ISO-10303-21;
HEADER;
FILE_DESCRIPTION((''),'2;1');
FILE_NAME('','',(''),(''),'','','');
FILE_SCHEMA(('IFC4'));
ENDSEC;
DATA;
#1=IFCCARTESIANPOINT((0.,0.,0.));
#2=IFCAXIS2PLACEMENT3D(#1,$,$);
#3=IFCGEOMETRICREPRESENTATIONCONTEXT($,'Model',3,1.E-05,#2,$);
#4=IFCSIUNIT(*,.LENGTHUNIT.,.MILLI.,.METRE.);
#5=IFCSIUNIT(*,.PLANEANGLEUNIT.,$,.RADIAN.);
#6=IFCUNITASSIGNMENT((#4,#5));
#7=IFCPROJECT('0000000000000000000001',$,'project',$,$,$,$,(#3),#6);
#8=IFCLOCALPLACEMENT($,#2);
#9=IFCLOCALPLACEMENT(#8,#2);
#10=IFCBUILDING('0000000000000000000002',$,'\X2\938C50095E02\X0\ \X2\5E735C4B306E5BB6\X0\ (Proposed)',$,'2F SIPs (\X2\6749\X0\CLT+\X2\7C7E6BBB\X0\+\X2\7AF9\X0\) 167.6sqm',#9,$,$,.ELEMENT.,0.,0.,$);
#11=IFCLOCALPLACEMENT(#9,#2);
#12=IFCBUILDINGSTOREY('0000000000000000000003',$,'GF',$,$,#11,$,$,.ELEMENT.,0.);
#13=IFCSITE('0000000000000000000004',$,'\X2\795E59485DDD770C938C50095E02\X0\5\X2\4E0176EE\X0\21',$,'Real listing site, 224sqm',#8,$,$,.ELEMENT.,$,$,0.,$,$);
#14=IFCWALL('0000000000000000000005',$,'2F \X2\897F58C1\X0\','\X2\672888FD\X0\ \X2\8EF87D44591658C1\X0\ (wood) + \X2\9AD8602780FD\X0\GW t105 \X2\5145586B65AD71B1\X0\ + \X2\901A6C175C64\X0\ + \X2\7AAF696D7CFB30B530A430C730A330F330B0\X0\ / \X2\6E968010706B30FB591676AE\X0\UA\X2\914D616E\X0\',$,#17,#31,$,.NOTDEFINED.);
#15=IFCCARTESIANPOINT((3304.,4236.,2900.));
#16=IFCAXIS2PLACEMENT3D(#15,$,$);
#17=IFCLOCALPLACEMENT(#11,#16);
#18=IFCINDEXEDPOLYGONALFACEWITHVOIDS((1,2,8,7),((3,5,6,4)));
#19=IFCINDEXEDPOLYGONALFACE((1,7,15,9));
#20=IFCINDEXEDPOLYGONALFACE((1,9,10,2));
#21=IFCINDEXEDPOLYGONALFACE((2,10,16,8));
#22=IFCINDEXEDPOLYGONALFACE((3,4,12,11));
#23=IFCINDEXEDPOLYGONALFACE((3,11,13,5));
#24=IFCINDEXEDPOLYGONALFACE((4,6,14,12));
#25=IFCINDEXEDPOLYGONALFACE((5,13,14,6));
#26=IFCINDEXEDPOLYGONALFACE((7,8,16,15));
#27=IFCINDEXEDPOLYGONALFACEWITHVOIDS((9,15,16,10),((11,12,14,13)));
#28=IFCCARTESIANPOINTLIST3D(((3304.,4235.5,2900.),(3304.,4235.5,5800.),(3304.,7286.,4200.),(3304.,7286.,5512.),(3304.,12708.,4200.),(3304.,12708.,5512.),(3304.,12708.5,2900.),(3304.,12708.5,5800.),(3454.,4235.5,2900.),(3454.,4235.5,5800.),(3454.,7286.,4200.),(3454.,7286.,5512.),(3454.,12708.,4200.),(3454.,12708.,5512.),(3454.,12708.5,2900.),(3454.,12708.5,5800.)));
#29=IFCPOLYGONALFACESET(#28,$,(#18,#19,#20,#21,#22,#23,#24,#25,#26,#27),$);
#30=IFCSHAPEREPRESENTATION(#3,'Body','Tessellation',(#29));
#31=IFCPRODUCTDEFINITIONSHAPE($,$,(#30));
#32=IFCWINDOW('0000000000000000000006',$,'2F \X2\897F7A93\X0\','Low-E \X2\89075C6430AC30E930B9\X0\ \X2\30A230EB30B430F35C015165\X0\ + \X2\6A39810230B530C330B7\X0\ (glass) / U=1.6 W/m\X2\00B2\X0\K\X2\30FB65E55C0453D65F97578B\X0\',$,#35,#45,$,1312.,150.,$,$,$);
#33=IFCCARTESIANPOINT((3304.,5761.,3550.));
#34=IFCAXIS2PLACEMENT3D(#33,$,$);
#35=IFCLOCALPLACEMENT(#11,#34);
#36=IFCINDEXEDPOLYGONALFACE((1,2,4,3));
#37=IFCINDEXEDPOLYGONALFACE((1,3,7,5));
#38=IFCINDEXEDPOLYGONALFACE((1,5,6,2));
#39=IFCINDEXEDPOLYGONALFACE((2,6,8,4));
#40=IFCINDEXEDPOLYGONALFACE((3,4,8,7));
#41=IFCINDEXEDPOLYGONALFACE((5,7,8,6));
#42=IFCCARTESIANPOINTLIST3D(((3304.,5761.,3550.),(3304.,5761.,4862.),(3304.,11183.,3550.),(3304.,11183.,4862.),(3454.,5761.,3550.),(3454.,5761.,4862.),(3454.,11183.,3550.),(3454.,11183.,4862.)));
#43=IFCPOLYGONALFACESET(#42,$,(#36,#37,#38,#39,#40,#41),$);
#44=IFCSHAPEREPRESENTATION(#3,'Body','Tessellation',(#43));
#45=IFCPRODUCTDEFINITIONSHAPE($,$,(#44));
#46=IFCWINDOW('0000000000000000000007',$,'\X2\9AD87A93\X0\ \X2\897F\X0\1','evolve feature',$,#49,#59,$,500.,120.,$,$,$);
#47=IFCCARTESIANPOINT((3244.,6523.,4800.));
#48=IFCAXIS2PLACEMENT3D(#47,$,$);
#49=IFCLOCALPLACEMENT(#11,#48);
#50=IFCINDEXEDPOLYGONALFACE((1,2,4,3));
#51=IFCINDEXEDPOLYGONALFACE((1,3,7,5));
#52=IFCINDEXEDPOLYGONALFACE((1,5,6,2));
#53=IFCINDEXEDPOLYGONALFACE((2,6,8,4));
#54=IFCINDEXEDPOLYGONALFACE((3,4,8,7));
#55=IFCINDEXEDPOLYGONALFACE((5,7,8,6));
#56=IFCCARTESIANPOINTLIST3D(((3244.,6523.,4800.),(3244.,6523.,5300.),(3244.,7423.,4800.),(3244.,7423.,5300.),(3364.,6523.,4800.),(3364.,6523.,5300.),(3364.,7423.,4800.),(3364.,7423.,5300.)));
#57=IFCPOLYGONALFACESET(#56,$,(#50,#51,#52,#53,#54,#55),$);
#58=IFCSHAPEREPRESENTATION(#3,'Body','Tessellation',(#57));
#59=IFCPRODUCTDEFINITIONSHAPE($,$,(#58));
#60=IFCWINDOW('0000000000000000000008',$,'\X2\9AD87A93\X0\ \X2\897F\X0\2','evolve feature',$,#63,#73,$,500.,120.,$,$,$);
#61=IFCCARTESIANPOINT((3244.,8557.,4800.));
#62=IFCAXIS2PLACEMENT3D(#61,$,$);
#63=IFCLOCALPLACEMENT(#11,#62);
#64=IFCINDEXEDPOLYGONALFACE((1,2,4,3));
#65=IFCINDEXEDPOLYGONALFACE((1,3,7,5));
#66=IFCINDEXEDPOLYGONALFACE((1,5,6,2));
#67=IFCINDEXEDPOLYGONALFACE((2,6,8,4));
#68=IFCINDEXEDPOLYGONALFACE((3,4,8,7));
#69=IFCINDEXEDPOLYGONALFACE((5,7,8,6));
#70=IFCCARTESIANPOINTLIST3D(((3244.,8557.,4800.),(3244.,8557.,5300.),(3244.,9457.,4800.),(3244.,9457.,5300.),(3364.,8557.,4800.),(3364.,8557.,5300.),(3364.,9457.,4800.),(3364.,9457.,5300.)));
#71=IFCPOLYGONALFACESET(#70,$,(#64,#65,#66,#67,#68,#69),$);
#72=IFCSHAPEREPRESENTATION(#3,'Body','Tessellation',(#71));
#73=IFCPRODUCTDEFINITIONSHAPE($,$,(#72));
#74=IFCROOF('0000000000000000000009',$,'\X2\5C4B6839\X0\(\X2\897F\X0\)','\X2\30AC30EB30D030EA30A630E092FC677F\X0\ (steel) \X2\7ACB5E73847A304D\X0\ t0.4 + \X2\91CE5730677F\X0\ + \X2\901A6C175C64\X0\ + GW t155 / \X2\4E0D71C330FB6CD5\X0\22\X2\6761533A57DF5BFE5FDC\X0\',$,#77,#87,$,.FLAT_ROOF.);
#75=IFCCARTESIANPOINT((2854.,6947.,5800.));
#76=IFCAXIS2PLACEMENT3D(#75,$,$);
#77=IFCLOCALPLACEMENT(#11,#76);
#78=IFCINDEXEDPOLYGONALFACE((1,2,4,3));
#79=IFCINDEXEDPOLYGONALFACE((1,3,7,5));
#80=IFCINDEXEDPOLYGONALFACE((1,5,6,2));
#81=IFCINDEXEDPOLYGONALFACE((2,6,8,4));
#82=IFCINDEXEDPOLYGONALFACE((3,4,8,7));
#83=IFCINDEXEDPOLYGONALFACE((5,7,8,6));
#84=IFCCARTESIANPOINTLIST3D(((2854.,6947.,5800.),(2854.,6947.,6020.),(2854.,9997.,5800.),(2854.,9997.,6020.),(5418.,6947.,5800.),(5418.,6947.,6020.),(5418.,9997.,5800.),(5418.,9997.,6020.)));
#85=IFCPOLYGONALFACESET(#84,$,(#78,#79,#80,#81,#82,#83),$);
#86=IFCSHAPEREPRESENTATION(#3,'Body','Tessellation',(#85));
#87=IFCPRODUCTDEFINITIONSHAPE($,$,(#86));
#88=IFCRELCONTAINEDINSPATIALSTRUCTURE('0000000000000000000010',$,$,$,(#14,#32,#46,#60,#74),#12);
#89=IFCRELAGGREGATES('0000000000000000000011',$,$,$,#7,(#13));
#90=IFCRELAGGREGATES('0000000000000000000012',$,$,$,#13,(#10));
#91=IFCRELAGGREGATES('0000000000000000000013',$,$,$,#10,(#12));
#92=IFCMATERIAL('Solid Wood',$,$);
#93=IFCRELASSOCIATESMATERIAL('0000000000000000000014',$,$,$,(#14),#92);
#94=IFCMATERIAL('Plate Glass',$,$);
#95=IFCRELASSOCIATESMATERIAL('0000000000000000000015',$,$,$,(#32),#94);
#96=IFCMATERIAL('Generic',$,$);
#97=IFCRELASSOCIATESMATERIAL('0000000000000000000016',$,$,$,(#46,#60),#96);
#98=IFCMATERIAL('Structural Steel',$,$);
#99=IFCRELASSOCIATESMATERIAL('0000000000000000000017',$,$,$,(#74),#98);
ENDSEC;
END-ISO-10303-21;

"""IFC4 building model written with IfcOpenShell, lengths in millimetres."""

from ifc_helpers import new_model, si_unit, frame, frame_2d, origin, place, context, project, spatial, rectangle, extrude, material, element, fill, save


model = new_model("IFC4")

# Units and contexts
model_context = context("Model", 3, precision=1e-05, world=origin())
ifc_project = project(units=[si_unit("LENGTHUNIT", "METRE", prefix="MILLI"), si_unit("PLANEANGLEUNIT", "RADIAN")], contexts=[model_context])

# Site, building, storey
site_placement = place(None, origin())
site = spatial("IfcSite", under=ifc_project, at=site_placement, Name="神奈川県鎌倉市5丁目21", ObjectType="Real listing site, 224sqm", CompositionType="ELEMENT", RefElevation=0.0)
building_placement = place(site_placement, origin())
building = spatial("IfcBuilding", under=site, at=building_placement, Name="鎌倉市 平屋の家 (Proposed)", ObjectType="2F SIPs (杉CLT+籾殻+竹) 167.6sqm", CompositionType="ELEMENT", ElevationOfRefHeight=0.0, ElevationOfTerrain=0.0)
storey_placement = place(building_placement, origin())
storey = spatial("IfcBuildingStorey", under=building, at=storey_placement, Name="GF", CompositionType="ELEMENT", Elevation=0.0)

# Shared definitions
ifc_material_1 = material(Name="Solid Wood")
ifc_material_2 = material(Name="Generic")

# Shared definitions
ifc_material_3 = material(Name="Plate Glass")

# Wall, openings, windows
wall_1_placement = place(storey_placement, frame((3304.0, 4236.0, 2900.0)))
wall_1 = element("IfcWall", 1, at=wall_1_placement, inside=storey, material=ifc_material_1, Name="2F 西壁", Description="木製 軸組外壁 (wood) + 高性能GW t105 充填断熱 + 通気層 + 窯業系サイディング / 準耐火・外皮UA配慮", PredefinedType="NOTDEFINED", context=model_context, shape_type="SweptSolid", body=[
    extrude(rectangle(XDim=150.0, YDim=8473.0, at=frame_2d((75.0, 4236.0))), frame((3304.0, 4236.0, 2900.0)), (0.0, 0.0, 1.0), 2900.0),
])
opening_1_placement = place(storey_placement, frame((3304.0, 5761.0, 3550.0)))
opening_1 = element("IfcOpeningElement", 2, at=opening_1_placement, cuts=wall_1, PredefinedType="NOTDEFINED", context=model_context, shape_type="SweptSolid", body=[
    extrude(rectangle(XDim=150.0, YDim=5422.0, at=frame_2d((75.0, 2711.0))), frame((3304.0, 5761.0, 3550.0)), (0.0, 0.0, 1.0), 1312.0),
])
opening_2_placement = place(storey_placement, frame((3244.0, 6523.0, 4800.0)))
opening_2 = element("IfcOpeningElement", 3, at=opening_2_placement, cuts=wall_1, PredefinedType="NOTDEFINED", context=model_context, shape_type="SweptSolid", body=[
    extrude(rectangle(XDim=120.0, YDim=900.0, at=frame_2d((60.0, 450.0))), frame((3244.0, 6523.0, 4800.0)), (0.0, 0.0, 1.0), 500.0),
])
opening_3_placement = place(storey_placement, frame((3244.0, 8557.0, 4800.0)))
opening_3 = element("IfcOpeningElement", 4, at=opening_3_placement, cuts=wall_1, PredefinedType="NOTDEFINED", context=model_context, shape_type="SweptSolid", body=[
    extrude(rectangle(XDim=120.0, YDim=900.0, at=frame_2d((60.0, 450.0))), frame((3244.0, 8557.0, 4800.0)), (0.0, 0.0, 1.0), 500.0),
])
window_1_placement = place(storey_placement, frame((3304.0, 5761.0, 3550.0)))
window_1 = element("IfcWindow", 5, at=window_1_placement, inside=storey, material=ifc_material_3, Name="2F 西窓", Description="Low-E 複層ガラス アルゴン封入 + 樹脂サッシ (glass) / U=1.6 W/m²K・日射取得型", OverallHeight=1312.0, OverallWidth=150.0, context=model_context, shape_type="SweptSolid", body=[
    extrude(rectangle(XDim=150.0, YDim=5422.0, at=frame_2d((75.0, 2711.0))), frame((3304.0, 5761.0, 3550.0)), (0.0, 0.0, 1.0), 1312.0),
])
fill(opening_1, window_1)
window_2_placement = place(storey_placement, frame((3244.0, 6523.0, 4800.0)))
window_2 = element("IfcWindow", 6, at=window_2_placement, inside=storey, material=ifc_material_2, Name="高窓 西1", Description="evolve feature", OverallHeight=500.0, OverallWidth=120.0, context=model_context, shape_type="SweptSolid", body=[
    extrude(rectangle(XDim=120.0, YDim=900.0, at=frame_2d((60.0, 450.0))), frame((3244.0, 6523.0, 4800.0)), (0.0, 0.0, 1.0), 500.0),
])
fill(opening_2, window_2)
window_3_placement = place(storey_placement, frame((3244.0, 8557.0, 4800.0)))
window_3 = element("IfcWindow", 7, at=window_3_placement, inside=storey, material=ifc_material_2, Name="高窓 西2", Description="evolve feature", OverallHeight=500.0, OverallWidth=120.0, context=model_context, shape_type="SweptSolid", body=[
    extrude(rectangle(XDim=120.0, YDim=900.0, at=frame_2d((60.0, 450.0))), frame((3244.0, 8557.0, 4800.0)), (0.0, 0.0, 1.0), 500.0),
])
fill(opening_3, window_3)

# Roof
ifc_material_4 = material(Name="Structural Steel")
roof_1_placement = place(storey_placement, frame((2854.0, 6947.0, 5800.0)))
element("IfcRoof", 8, at=roof_1_placement, inside=storey, material=ifc_material_4, Name="屋根(西)", Description="ガルバリウム鋼板 (steel) 立平葺き t0.4 + 野地板 + 通気層 + GW t155 / 不燃・法22条区域対応", PredefinedType="FLAT_ROOF", context=model_context, shape_type="SweptSolid", body=[
    extrude(rectangle(XDim=2564.0, YDim=3050.0, at=frame_2d((1282.0, 1525.0))), frame((2854.0, 6947.0, 5800.0)), (0.0, 0.0, 1.0), 220.0),
])

save(model, "model.ifc")
